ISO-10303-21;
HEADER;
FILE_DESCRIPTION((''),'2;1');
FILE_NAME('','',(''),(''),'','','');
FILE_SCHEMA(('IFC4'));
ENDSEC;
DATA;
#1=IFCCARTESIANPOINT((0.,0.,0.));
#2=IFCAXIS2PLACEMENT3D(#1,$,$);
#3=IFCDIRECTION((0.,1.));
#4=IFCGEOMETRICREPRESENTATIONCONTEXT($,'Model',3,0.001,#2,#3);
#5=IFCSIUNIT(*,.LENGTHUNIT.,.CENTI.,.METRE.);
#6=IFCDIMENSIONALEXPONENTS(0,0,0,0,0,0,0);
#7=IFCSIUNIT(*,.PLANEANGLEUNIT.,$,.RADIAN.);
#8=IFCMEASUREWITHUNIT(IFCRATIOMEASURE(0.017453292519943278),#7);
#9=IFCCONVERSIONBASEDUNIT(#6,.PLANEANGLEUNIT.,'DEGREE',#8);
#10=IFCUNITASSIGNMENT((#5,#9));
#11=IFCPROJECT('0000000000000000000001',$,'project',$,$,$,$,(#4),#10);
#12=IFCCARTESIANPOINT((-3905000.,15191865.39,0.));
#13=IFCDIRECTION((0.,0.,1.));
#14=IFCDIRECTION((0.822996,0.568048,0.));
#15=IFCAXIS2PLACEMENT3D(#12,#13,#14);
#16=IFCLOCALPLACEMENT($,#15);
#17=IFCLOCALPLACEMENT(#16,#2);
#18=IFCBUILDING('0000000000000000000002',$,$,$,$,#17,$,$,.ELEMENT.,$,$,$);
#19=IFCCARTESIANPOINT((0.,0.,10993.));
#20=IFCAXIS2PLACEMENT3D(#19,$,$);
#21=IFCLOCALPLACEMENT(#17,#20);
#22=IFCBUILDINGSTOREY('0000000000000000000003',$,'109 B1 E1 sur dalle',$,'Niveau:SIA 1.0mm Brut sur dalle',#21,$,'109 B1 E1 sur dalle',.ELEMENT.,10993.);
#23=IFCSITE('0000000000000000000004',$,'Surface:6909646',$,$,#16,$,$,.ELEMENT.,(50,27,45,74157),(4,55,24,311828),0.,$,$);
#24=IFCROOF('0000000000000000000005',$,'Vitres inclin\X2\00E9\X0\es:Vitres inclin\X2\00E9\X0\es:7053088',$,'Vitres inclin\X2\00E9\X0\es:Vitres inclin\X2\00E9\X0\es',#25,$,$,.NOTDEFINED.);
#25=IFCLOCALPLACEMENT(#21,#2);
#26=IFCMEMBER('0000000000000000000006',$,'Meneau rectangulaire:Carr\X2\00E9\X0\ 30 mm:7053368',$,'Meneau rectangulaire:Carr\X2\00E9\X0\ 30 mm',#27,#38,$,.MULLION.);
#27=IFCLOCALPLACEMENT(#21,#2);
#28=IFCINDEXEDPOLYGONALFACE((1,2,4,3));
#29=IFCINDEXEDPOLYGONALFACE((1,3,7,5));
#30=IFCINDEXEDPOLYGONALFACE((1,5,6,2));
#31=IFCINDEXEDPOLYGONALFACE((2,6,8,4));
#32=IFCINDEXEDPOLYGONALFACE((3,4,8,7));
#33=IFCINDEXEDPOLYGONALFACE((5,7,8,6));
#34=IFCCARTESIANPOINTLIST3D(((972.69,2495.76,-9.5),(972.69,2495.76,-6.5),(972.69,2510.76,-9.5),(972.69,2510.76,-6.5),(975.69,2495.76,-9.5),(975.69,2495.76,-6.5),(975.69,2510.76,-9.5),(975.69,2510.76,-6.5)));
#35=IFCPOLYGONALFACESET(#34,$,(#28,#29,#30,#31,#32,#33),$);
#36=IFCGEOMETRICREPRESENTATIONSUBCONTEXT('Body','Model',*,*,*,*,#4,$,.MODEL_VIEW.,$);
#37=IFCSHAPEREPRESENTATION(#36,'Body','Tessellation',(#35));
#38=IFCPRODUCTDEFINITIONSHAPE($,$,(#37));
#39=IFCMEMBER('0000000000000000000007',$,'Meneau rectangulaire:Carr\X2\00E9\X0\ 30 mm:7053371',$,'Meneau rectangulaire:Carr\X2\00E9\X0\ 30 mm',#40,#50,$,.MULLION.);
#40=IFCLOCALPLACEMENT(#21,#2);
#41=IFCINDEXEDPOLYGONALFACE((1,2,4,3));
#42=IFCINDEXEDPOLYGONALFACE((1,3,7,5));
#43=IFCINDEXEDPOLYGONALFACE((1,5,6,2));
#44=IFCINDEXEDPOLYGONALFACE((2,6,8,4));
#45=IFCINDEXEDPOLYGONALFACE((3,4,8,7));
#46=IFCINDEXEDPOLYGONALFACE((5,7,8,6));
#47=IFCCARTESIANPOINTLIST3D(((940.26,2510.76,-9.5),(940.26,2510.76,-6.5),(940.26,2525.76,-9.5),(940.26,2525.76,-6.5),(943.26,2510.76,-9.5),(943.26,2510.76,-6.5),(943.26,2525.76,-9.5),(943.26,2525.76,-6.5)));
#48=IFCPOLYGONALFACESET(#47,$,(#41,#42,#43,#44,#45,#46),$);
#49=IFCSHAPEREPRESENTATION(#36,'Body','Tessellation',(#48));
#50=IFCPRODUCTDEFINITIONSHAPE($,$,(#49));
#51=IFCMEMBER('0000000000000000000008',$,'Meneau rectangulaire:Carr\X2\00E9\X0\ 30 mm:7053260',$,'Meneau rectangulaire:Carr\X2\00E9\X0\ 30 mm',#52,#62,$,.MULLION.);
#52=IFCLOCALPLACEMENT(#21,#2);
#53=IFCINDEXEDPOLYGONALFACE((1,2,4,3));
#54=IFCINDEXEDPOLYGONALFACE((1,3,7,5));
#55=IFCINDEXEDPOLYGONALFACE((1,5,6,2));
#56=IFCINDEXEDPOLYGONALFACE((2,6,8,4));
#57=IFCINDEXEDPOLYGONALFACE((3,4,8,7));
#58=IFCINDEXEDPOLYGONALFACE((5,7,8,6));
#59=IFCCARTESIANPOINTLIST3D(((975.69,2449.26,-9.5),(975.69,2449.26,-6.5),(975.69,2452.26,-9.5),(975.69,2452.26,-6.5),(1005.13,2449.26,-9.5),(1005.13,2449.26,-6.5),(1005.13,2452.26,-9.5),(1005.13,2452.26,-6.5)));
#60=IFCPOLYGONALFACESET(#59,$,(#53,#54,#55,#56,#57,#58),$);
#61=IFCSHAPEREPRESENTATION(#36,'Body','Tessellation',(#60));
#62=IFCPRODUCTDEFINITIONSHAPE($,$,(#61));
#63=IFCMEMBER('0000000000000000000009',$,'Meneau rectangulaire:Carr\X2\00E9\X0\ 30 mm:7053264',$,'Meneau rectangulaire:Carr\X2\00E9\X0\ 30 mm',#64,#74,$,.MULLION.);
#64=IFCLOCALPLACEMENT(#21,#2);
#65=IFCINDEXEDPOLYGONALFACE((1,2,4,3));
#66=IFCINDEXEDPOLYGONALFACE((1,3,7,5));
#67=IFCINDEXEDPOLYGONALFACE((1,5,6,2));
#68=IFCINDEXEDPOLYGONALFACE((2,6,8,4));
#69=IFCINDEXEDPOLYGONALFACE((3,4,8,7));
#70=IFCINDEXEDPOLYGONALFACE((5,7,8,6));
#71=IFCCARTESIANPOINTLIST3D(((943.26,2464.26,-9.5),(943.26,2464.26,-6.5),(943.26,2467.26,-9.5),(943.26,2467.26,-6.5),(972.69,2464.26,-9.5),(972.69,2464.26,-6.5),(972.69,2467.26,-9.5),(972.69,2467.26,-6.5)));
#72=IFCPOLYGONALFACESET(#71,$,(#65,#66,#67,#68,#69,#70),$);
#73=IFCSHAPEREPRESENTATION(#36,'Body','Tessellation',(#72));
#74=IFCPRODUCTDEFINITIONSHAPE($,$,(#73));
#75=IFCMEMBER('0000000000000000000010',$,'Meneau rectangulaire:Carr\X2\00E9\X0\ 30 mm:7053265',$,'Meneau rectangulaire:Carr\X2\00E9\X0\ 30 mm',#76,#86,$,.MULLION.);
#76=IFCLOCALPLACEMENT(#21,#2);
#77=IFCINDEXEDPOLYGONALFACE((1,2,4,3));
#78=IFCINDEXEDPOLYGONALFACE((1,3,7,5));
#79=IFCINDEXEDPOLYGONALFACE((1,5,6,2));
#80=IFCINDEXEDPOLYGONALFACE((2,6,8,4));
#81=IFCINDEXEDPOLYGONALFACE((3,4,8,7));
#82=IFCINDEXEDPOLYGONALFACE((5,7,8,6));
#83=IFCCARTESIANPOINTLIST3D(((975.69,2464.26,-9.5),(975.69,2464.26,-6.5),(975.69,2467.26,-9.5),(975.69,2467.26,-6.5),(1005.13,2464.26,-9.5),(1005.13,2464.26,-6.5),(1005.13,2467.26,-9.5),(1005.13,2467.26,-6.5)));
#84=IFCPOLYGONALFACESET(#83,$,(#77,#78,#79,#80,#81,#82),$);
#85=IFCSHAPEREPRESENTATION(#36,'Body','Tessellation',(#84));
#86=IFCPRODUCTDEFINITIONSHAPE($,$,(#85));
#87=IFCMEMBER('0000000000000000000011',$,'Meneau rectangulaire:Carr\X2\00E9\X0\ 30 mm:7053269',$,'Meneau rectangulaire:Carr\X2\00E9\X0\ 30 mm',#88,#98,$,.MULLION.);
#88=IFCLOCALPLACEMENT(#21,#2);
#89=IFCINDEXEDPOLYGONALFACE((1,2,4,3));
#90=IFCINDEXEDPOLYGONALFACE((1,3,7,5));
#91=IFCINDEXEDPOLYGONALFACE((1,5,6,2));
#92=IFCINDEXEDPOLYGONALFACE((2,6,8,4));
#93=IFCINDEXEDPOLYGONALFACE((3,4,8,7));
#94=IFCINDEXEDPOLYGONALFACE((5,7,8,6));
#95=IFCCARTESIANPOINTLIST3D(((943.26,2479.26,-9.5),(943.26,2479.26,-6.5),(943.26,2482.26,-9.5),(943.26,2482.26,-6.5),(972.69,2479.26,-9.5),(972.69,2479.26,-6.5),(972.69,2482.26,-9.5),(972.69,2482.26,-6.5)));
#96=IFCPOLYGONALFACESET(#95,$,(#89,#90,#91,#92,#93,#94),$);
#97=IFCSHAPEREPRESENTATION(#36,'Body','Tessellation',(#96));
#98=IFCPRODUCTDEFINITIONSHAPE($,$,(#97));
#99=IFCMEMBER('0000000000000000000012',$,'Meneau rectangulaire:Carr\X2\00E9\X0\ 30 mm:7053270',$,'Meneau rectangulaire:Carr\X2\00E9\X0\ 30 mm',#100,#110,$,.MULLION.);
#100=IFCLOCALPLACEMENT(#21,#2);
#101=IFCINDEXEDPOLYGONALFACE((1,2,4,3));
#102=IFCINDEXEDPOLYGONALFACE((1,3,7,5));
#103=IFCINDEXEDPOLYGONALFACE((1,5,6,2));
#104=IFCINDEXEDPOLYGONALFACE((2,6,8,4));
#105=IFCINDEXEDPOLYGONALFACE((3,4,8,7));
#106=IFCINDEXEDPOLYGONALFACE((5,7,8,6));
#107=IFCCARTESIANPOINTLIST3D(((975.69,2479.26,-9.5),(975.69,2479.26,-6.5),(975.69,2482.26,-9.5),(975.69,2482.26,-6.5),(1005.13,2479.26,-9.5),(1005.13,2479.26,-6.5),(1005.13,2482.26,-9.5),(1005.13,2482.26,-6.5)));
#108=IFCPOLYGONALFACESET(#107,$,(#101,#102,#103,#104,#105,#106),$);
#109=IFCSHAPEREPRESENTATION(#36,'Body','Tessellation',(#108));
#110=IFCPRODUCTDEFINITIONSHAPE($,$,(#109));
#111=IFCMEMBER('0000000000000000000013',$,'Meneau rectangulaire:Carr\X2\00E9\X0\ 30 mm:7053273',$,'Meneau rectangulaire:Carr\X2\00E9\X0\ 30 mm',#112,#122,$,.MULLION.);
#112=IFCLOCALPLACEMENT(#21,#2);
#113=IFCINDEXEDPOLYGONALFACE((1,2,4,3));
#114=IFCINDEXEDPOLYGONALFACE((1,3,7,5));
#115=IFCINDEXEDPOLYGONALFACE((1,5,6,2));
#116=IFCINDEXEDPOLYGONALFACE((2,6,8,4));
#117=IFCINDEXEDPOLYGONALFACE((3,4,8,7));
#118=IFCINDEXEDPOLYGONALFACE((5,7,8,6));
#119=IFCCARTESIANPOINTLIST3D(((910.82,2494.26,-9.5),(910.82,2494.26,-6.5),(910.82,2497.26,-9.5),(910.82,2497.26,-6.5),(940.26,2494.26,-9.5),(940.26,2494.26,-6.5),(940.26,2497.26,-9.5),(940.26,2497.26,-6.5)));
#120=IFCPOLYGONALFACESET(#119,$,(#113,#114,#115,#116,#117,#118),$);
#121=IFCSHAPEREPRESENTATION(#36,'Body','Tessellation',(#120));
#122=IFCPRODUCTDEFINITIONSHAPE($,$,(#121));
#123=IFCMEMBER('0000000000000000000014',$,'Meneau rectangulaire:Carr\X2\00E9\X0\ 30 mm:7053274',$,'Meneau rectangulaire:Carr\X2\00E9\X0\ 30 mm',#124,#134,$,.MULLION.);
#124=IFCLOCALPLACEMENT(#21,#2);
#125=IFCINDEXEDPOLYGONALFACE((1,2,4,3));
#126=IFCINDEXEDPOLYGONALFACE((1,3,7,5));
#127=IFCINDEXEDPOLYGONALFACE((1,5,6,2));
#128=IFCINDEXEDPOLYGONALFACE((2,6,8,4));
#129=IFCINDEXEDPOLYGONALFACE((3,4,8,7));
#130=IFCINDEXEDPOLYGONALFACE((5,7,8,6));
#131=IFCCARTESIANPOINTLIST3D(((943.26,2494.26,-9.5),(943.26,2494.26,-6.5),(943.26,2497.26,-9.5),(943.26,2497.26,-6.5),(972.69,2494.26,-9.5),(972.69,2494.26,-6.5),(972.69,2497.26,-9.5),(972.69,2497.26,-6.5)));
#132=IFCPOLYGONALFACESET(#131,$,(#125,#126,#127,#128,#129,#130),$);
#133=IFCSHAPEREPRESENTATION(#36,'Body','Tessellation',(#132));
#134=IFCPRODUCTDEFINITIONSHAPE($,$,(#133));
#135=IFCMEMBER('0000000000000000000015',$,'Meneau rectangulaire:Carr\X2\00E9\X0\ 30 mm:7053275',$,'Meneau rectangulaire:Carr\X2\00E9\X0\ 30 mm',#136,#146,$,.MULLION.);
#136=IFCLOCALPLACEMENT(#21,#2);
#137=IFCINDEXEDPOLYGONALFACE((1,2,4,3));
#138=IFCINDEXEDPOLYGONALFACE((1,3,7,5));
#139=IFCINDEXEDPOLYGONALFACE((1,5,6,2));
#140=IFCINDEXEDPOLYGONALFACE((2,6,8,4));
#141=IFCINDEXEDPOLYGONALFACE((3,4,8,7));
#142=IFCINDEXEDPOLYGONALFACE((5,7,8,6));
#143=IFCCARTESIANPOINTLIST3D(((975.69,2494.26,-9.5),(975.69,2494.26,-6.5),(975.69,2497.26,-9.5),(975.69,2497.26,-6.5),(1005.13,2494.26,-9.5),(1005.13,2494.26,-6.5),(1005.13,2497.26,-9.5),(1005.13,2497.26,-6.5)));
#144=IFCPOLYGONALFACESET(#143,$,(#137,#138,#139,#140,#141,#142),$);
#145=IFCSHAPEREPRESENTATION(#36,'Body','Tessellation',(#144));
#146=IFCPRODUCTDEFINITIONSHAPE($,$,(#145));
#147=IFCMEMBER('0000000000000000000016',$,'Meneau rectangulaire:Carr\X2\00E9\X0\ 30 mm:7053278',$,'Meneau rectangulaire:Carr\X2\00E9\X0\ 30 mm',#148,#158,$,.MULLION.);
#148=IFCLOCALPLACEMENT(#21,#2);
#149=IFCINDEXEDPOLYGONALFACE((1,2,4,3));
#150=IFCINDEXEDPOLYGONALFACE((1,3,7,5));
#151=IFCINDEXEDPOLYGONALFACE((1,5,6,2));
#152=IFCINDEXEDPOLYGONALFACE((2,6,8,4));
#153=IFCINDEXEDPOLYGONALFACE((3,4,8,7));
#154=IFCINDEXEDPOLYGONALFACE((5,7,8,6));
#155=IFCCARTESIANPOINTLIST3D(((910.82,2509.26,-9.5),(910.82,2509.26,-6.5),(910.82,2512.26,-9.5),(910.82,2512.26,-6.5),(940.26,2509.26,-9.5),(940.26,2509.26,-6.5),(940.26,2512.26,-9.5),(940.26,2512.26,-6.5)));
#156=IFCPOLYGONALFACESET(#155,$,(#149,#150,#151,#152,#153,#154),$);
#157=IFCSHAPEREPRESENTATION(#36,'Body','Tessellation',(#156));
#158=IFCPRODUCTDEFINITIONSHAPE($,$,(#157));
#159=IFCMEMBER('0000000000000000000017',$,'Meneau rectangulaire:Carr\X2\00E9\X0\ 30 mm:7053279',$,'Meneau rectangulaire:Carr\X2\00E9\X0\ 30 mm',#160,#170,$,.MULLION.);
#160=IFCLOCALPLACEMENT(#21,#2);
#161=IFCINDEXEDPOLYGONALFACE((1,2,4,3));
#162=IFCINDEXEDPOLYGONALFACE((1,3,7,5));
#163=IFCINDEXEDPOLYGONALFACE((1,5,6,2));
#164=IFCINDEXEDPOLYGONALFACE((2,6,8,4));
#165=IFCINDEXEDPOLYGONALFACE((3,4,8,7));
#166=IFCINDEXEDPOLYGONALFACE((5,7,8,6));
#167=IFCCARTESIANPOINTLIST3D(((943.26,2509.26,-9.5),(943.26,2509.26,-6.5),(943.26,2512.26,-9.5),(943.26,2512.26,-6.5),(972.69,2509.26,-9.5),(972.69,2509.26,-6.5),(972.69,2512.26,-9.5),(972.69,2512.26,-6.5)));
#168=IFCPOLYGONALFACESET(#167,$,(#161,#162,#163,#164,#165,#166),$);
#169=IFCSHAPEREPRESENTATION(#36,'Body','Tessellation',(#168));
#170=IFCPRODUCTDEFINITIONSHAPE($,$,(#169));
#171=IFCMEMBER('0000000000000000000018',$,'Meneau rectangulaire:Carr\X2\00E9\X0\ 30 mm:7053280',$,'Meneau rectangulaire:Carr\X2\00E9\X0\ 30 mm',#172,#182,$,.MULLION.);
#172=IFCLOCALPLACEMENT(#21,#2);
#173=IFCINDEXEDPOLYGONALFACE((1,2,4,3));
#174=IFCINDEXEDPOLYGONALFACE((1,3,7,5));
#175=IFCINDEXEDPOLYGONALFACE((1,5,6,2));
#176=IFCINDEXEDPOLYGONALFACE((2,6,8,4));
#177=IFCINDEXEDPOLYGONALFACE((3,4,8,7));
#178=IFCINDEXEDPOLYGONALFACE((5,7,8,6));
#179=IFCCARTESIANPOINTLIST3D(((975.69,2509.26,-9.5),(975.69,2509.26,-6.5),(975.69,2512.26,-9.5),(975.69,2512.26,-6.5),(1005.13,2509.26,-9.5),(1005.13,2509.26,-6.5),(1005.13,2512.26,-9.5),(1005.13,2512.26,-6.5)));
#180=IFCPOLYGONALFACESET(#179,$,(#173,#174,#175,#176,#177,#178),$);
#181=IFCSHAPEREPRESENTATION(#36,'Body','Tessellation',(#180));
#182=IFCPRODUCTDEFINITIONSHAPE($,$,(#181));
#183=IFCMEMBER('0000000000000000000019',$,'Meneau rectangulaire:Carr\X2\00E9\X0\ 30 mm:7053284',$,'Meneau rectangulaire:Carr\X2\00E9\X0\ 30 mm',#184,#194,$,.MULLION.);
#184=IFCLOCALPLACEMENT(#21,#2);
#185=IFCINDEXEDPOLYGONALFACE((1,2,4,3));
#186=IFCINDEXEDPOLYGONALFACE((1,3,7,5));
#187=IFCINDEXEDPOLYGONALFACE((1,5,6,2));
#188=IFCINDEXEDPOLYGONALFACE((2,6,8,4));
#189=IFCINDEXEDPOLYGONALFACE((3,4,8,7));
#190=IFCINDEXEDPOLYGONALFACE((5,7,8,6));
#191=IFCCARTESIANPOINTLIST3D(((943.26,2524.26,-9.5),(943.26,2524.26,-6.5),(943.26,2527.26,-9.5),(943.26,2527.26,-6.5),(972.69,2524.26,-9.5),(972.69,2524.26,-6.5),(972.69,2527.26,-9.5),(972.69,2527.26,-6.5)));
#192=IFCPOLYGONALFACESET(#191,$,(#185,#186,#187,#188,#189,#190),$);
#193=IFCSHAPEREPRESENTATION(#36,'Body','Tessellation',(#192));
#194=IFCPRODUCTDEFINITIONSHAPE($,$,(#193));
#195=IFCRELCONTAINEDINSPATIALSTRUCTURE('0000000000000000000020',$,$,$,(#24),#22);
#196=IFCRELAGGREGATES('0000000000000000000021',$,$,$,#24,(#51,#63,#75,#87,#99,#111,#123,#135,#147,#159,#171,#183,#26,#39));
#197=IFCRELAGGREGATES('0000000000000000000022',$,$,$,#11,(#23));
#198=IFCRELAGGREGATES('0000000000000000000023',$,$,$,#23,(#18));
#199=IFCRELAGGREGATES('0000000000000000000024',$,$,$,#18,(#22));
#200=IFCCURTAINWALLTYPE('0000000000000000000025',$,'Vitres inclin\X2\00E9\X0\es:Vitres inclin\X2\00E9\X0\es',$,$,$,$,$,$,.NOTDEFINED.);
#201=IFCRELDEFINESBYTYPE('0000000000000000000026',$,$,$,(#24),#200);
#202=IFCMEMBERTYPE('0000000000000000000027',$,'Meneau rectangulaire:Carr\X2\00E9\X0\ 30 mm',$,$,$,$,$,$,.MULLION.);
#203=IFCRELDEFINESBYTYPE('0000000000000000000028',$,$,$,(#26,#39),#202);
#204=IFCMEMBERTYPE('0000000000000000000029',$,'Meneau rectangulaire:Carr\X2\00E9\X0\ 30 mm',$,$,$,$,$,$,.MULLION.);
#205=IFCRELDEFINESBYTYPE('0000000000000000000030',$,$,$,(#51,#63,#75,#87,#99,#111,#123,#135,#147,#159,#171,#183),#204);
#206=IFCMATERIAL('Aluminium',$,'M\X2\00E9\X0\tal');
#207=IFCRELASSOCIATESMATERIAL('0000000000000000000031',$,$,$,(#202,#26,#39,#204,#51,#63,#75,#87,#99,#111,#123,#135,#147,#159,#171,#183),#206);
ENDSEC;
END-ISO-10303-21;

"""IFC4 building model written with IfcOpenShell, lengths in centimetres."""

from ifc_helpers import new_model, entity, si_unit, converted_unit, direction, frame, origin, place, context, subcontext, project, spatial, indexed_curve, outline, extrude, source, transform, mapped, material, type_object, type_shapes, element, aggregate, save


model = new_model("IFC4")

# Units and contexts
model_context = context("Model", 3, precision=0.001, world=origin(), true_north=direction((0.0, 1.0)))
body_context = subcontext(model_context, "Body", "Model", "MODEL_VIEW")
ifc_project = project(units=[si_unit("LENGTHUNIT", "METRE", prefix="CENTI"), converted_unit("PLANEANGLEUNIT", "DEGREE", entity("IfcRatioMeasure", 0.017453292519943278), si_unit("PLANEANGLEUNIT", "RADIAN"), dimensions=[0, 0, 0, 0, 0, 0, 0])], contexts=[model_context])

# Site, building, storey
site_placement = place(None, frame((-3905000.0, 15191865.39, 0.0), z_axis=(0.0, 0.0, 1.0), x_axis=(0.822996, 0.568048, 0.0)))
site = spatial("IfcSite", under=ifc_project, at=site_placement, Name="Surface:6909646", CompositionType="ELEMENT", RefLatitude=(50, 27, 45, 74157), RefLongitude=(4, 55, 24, 311828), RefElevation=0.0)
building_placement = place(site_placement, origin())
building = spatial("IfcBuilding", under=site, at=building_placement, CompositionType="ELEMENT")
storey_placement = place(building_placement, frame((0.0, 0.0, 10993.0)))
storey = spatial("IfcBuildingStorey", under=building, at=storey_placement, Name="109 B1 E1 sur dalle", ObjectType="Niveau:SIA 1.0mm Brut sur dalle", LongName="109 B1 E1 sur dalle", CompositionType="ELEMENT", Elevation=10993.0)

# Roof, members
curtain_wall_type = type_object("IfcCurtainWallType", Name="Vitres inclinées:Vitres inclinées", PredefinedType="NOTDEFINED")
roof_placement = place(storey_placement, frame((0.0, 0.0, -10993.0)))
roof = element("IfcRoof", 1, at=roof_placement, inside=storey, type_object=curtain_wall_type, Name="Vitres inclinées:Vitres inclinées:7053088", ObjectType="Vitres inclinées:Vitres inclinées", PredefinedType="NOTDEFINED")
ifc_material = material(Name="Aluminium", Category="Métal")
member_type_1 = type_object("IfcMemberType", Name="Meneau rectangulaire:Carré 30 mm", PredefinedType="MULLION", material=ifc_material)
shared_shape_1 = source(origin(), body_context, "Body", "SweptSolid", [
    extrude(outline(indexed_curve([(-1.5, -1.5), (1.5, -1.5), (1.5, 1.5), (-1.5, 1.5), (-1.5, -1.5)], self_intersect=False)), frame((0.0, 0.0, -15.0), z_axis=(0.0, 0.0, 1.0), x_axis=(0.0, -1.0, 0.0)), (0.0, 0.0, 1.0), 15.0),
])
type_shapes(member_type_1, [shared_shape_1])
member_1_placement = place(roof_placement, frame((974.19, 2510.76, 10985.0), z_axis=(0.0, 1.0, 0.0), x_axis=(1.0, 0.0, 0.0)))
member_1 = element("IfcMember", 2, at=member_1_placement, type_object=member_type_1, material=ifc_material, Name="Meneau rectangulaire:Carré 30 mm:7053368", ObjectType="Meneau rectangulaire:Carré 30 mm", PredefinedType="MULLION", context=body_context, shape_type="MappedRepresentation", body=[
    mapped(shared_shape_1, transform((0.0, 0.0, 0.0), scale=1.0)),
])
member_2_placement = place(roof_placement, frame((941.76, 2525.76, 10985.0), z_axis=(0.0, 1.0, 0.0), x_axis=(1.0, 0.0, 0.0)))
member_2 = element("IfcMember", 3, at=member_2_placement, type_object=member_type_1, material=ifc_material, Name="Meneau rectangulaire:Carré 30 mm:7053371", ObjectType="Meneau rectangulaire:Carré 30 mm", PredefinedType="MULLION", context=body_context, shape_type="MappedRepresentation", body=[
    mapped(shared_shape_1, transform((0.0, 0.0, 0.0), scale=1.0)),
])
member_type_2 = type_object("IfcMemberType", Name="Meneau rectangulaire:Carré 30 mm", PredefinedType="MULLION", material=ifc_material)
shared_shape_2 = source(origin(), body_context, "Body", "SweptSolid", [
    extrude(outline(indexed_curve([(-1.5, -1.5), (1.5, -1.5), (1.5, 1.5), (-1.5, 1.5), (-1.5, -1.5)], self_intersect=False)), frame((0.0, 0.0, -29.44), z_axis=(0.0, 0.0, 1.0), x_axis=(0.0, -1.0, 0.0)), (0.0, 0.0, 1.0), 29.44),
])
type_shapes(member_type_2, [shared_shape_2])
member_3_placement = place(roof_placement, frame((975.69, 2450.76, 10985.0), z_axis=(-1.0, 0.0, 0.0), x_axis=(0.0, 1.0, 0.0)))
member_3 = element("IfcMember", 4, at=member_3_placement, type_object=member_type_2, material=ifc_material, Name="Meneau rectangulaire:Carré 30 mm:7053260", ObjectType="Meneau rectangulaire:Carré 30 mm", PredefinedType="MULLION", context=body_context, shape_type="MappedRepresentation", body=[
    mapped(shared_shape_2, transform((0.0, 0.0, 0.0), scale=1.0)),
])
member_4_placement = place(roof_placement, frame((943.26, 2465.76, 10985.0), z_axis=(-1.0, 0.0, 0.0), x_axis=(0.0, 1.0, 0.0)))
member_4 = element("IfcMember", 5, at=member_4_placement, type_object=member_type_2, material=ifc_material, Name="Meneau rectangulaire:Carré 30 mm:7053264", ObjectType="Meneau rectangulaire:Carré 30 mm", PredefinedType="MULLION", context=body_context, shape_type="MappedRepresentation", body=[
    mapped(shared_shape_2, transform((0.0, 0.0, 0.0), scale=1.0)),
])
member_5_placement = place(roof_placement, frame((975.69, 2465.76, 10985.0), z_axis=(-1.0, 0.0, 0.0), x_axis=(0.0, 1.0, 0.0)))
member_5 = element("IfcMember", 6, at=member_5_placement, type_object=member_type_2, material=ifc_material, Name="Meneau rectangulaire:Carré 30 mm:7053265", ObjectType="Meneau rectangulaire:Carré 30 mm", PredefinedType="MULLION", context=body_context, shape_type="MappedRepresentation", body=[
    mapped(shared_shape_2, transform((0.0, 0.0, 0.0), scale=1.0)),
])
member_6_placement = place(roof_placement, frame((943.26, 2480.76, 10985.0), z_axis=(-1.0, 0.0, 0.0), x_axis=(0.0, 1.0, 0.0)))
member_6 = element("IfcMember", 7, at=member_6_placement, type_object=member_type_2, material=ifc_material, Name="Meneau rectangulaire:Carré 30 mm:7053269", ObjectType="Meneau rectangulaire:Carré 30 mm", PredefinedType="MULLION", context=body_context, shape_type="MappedRepresentation", body=[
    mapped(shared_shape_2, transform((0.0, 0.0, 0.0), scale=1.0)),
])
member_7_placement = place(roof_placement, frame((975.69, 2480.76, 10985.0), z_axis=(-1.0, 0.0, 0.0), x_axis=(0.0, 1.0, 0.0)))
member_7 = element("IfcMember", 8, at=member_7_placement, type_object=member_type_2, material=ifc_material, Name="Meneau rectangulaire:Carré 30 mm:7053270", ObjectType="Meneau rectangulaire:Carré 30 mm", PredefinedType="MULLION", context=body_context, shape_type="MappedRepresentation", body=[
    mapped(shared_shape_2, transform((0.0, 0.0, 0.0), scale=1.0)),
])
member_8_placement = place(roof_placement, frame((910.82, 2495.76, 10985.0), z_axis=(-1.0, 0.0, 0.0), x_axis=(0.0, 1.0, 0.0)))
member_8 = element("IfcMember", 9, at=member_8_placement, type_object=member_type_2, material=ifc_material, Name="Meneau rectangulaire:Carré 30 mm:7053273", ObjectType="Meneau rectangulaire:Carré 30 mm", PredefinedType="MULLION", context=body_context, shape_type="MappedRepresentation", body=[
    mapped(shared_shape_2, transform((0.0, 0.0, 0.0), scale=1.0)),
])
member_9_placement = place(roof_placement, frame((943.26, 2495.76, 10985.0), z_axis=(-1.0, 0.0, 0.0), x_axis=(0.0, 1.0, 0.0)))
member_9 = element("IfcMember", 10, at=member_9_placement, type_object=member_type_2, material=ifc_material, Name="Meneau rectangulaire:Carré 30 mm:7053274", ObjectType="Meneau rectangulaire:Carré 30 mm", PredefinedType="MULLION", context=body_context, shape_type="MappedRepresentation", body=[
    mapped(shared_shape_2, transform((0.0, 0.0, 0.0), scale=1.0)),
])
member_10_placement = place(roof_placement, frame((975.69, 2495.76, 10985.0), z_axis=(-1.0, 0.0, 0.0), x_axis=(0.0, 1.0, 0.0)))
member_10 = element("IfcMember", 11, at=member_10_placement, type_object=member_type_2, material=ifc_material, Name="Meneau rectangulaire:Carré 30 mm:7053275", ObjectType="Meneau rectangulaire:Carré 30 mm", PredefinedType="MULLION", context=body_context, shape_type="MappedRepresentation", body=[
    mapped(shared_shape_2, transform((0.0, 0.0, 0.0), scale=1.0)),
])
member_11_placement = place(roof_placement, frame((910.82, 2510.76, 10985.0), z_axis=(-1.0, 0.0, 0.0), x_axis=(0.0, 1.0, 0.0)))
member_11 = element("IfcMember", 12, at=member_11_placement, type_object=member_type_2, material=ifc_material, Name="Meneau rectangulaire:Carré 30 mm:7053278", ObjectType="Meneau rectangulaire:Carré 30 mm", PredefinedType="MULLION", context=body_context, shape_type="MappedRepresentation", body=[
    mapped(shared_shape_2, transform((0.0, 0.0, 0.0), scale=1.0)),
])
member_12_placement = place(roof_placement, frame((943.26, 2510.76, 10985.0), z_axis=(-1.0, 0.0, 0.0), x_axis=(0.0, 1.0, 0.0)))
member_12 = element("IfcMember", 13, at=member_12_placement, type_object=member_type_2, material=ifc_material, Name="Meneau rectangulaire:Carré 30 mm:7053279", ObjectType="Meneau rectangulaire:Carré 30 mm", PredefinedType="MULLION", context=body_context, shape_type="MappedRepresentation", body=[
    mapped(shared_shape_2, transform((0.0, 0.0, 0.0), scale=1.0)),
])
member_13_placement = place(roof_placement, frame((975.69, 2510.76, 10985.0), z_axis=(-1.0, 0.0, 0.0), x_axis=(0.0, 1.0, 0.0)))
member_13 = element("IfcMember", 14, at=member_13_placement, type_object=member_type_2, material=ifc_material, Name="Meneau rectangulaire:Carré 30 mm:7053280", ObjectType="Meneau rectangulaire:Carré 30 mm", PredefinedType="MULLION", context=body_context, shape_type="MappedRepresentation", body=[
    mapped(shared_shape_2, transform((0.0, 0.0, 0.0), scale=1.0)),
])
member_14_placement = place(roof_placement, frame((943.26, 2525.76, 10985.0), z_axis=(-1.0, 0.0, 0.0), x_axis=(0.0, 1.0, 0.0)))
member_14 = element("IfcMember", 15, at=member_14_placement, type_object=member_type_2, material=ifc_material, Name="Meneau rectangulaire:Carré 30 mm:7053284", ObjectType="Meneau rectangulaire:Carré 30 mm", PredefinedType="MULLION", context=body_context, shape_type="MappedRepresentation", body=[
    mapped(shared_shape_2, transform((0.0, 0.0, 0.0), scale=1.0)),
])
aggregate(roof, [member_3, member_4, member_5, member_6, member_7, member_8, member_9, member_10, member_11, member_12, member_13, member_14, member_1, member_2])

save(model, "model.ifc")
